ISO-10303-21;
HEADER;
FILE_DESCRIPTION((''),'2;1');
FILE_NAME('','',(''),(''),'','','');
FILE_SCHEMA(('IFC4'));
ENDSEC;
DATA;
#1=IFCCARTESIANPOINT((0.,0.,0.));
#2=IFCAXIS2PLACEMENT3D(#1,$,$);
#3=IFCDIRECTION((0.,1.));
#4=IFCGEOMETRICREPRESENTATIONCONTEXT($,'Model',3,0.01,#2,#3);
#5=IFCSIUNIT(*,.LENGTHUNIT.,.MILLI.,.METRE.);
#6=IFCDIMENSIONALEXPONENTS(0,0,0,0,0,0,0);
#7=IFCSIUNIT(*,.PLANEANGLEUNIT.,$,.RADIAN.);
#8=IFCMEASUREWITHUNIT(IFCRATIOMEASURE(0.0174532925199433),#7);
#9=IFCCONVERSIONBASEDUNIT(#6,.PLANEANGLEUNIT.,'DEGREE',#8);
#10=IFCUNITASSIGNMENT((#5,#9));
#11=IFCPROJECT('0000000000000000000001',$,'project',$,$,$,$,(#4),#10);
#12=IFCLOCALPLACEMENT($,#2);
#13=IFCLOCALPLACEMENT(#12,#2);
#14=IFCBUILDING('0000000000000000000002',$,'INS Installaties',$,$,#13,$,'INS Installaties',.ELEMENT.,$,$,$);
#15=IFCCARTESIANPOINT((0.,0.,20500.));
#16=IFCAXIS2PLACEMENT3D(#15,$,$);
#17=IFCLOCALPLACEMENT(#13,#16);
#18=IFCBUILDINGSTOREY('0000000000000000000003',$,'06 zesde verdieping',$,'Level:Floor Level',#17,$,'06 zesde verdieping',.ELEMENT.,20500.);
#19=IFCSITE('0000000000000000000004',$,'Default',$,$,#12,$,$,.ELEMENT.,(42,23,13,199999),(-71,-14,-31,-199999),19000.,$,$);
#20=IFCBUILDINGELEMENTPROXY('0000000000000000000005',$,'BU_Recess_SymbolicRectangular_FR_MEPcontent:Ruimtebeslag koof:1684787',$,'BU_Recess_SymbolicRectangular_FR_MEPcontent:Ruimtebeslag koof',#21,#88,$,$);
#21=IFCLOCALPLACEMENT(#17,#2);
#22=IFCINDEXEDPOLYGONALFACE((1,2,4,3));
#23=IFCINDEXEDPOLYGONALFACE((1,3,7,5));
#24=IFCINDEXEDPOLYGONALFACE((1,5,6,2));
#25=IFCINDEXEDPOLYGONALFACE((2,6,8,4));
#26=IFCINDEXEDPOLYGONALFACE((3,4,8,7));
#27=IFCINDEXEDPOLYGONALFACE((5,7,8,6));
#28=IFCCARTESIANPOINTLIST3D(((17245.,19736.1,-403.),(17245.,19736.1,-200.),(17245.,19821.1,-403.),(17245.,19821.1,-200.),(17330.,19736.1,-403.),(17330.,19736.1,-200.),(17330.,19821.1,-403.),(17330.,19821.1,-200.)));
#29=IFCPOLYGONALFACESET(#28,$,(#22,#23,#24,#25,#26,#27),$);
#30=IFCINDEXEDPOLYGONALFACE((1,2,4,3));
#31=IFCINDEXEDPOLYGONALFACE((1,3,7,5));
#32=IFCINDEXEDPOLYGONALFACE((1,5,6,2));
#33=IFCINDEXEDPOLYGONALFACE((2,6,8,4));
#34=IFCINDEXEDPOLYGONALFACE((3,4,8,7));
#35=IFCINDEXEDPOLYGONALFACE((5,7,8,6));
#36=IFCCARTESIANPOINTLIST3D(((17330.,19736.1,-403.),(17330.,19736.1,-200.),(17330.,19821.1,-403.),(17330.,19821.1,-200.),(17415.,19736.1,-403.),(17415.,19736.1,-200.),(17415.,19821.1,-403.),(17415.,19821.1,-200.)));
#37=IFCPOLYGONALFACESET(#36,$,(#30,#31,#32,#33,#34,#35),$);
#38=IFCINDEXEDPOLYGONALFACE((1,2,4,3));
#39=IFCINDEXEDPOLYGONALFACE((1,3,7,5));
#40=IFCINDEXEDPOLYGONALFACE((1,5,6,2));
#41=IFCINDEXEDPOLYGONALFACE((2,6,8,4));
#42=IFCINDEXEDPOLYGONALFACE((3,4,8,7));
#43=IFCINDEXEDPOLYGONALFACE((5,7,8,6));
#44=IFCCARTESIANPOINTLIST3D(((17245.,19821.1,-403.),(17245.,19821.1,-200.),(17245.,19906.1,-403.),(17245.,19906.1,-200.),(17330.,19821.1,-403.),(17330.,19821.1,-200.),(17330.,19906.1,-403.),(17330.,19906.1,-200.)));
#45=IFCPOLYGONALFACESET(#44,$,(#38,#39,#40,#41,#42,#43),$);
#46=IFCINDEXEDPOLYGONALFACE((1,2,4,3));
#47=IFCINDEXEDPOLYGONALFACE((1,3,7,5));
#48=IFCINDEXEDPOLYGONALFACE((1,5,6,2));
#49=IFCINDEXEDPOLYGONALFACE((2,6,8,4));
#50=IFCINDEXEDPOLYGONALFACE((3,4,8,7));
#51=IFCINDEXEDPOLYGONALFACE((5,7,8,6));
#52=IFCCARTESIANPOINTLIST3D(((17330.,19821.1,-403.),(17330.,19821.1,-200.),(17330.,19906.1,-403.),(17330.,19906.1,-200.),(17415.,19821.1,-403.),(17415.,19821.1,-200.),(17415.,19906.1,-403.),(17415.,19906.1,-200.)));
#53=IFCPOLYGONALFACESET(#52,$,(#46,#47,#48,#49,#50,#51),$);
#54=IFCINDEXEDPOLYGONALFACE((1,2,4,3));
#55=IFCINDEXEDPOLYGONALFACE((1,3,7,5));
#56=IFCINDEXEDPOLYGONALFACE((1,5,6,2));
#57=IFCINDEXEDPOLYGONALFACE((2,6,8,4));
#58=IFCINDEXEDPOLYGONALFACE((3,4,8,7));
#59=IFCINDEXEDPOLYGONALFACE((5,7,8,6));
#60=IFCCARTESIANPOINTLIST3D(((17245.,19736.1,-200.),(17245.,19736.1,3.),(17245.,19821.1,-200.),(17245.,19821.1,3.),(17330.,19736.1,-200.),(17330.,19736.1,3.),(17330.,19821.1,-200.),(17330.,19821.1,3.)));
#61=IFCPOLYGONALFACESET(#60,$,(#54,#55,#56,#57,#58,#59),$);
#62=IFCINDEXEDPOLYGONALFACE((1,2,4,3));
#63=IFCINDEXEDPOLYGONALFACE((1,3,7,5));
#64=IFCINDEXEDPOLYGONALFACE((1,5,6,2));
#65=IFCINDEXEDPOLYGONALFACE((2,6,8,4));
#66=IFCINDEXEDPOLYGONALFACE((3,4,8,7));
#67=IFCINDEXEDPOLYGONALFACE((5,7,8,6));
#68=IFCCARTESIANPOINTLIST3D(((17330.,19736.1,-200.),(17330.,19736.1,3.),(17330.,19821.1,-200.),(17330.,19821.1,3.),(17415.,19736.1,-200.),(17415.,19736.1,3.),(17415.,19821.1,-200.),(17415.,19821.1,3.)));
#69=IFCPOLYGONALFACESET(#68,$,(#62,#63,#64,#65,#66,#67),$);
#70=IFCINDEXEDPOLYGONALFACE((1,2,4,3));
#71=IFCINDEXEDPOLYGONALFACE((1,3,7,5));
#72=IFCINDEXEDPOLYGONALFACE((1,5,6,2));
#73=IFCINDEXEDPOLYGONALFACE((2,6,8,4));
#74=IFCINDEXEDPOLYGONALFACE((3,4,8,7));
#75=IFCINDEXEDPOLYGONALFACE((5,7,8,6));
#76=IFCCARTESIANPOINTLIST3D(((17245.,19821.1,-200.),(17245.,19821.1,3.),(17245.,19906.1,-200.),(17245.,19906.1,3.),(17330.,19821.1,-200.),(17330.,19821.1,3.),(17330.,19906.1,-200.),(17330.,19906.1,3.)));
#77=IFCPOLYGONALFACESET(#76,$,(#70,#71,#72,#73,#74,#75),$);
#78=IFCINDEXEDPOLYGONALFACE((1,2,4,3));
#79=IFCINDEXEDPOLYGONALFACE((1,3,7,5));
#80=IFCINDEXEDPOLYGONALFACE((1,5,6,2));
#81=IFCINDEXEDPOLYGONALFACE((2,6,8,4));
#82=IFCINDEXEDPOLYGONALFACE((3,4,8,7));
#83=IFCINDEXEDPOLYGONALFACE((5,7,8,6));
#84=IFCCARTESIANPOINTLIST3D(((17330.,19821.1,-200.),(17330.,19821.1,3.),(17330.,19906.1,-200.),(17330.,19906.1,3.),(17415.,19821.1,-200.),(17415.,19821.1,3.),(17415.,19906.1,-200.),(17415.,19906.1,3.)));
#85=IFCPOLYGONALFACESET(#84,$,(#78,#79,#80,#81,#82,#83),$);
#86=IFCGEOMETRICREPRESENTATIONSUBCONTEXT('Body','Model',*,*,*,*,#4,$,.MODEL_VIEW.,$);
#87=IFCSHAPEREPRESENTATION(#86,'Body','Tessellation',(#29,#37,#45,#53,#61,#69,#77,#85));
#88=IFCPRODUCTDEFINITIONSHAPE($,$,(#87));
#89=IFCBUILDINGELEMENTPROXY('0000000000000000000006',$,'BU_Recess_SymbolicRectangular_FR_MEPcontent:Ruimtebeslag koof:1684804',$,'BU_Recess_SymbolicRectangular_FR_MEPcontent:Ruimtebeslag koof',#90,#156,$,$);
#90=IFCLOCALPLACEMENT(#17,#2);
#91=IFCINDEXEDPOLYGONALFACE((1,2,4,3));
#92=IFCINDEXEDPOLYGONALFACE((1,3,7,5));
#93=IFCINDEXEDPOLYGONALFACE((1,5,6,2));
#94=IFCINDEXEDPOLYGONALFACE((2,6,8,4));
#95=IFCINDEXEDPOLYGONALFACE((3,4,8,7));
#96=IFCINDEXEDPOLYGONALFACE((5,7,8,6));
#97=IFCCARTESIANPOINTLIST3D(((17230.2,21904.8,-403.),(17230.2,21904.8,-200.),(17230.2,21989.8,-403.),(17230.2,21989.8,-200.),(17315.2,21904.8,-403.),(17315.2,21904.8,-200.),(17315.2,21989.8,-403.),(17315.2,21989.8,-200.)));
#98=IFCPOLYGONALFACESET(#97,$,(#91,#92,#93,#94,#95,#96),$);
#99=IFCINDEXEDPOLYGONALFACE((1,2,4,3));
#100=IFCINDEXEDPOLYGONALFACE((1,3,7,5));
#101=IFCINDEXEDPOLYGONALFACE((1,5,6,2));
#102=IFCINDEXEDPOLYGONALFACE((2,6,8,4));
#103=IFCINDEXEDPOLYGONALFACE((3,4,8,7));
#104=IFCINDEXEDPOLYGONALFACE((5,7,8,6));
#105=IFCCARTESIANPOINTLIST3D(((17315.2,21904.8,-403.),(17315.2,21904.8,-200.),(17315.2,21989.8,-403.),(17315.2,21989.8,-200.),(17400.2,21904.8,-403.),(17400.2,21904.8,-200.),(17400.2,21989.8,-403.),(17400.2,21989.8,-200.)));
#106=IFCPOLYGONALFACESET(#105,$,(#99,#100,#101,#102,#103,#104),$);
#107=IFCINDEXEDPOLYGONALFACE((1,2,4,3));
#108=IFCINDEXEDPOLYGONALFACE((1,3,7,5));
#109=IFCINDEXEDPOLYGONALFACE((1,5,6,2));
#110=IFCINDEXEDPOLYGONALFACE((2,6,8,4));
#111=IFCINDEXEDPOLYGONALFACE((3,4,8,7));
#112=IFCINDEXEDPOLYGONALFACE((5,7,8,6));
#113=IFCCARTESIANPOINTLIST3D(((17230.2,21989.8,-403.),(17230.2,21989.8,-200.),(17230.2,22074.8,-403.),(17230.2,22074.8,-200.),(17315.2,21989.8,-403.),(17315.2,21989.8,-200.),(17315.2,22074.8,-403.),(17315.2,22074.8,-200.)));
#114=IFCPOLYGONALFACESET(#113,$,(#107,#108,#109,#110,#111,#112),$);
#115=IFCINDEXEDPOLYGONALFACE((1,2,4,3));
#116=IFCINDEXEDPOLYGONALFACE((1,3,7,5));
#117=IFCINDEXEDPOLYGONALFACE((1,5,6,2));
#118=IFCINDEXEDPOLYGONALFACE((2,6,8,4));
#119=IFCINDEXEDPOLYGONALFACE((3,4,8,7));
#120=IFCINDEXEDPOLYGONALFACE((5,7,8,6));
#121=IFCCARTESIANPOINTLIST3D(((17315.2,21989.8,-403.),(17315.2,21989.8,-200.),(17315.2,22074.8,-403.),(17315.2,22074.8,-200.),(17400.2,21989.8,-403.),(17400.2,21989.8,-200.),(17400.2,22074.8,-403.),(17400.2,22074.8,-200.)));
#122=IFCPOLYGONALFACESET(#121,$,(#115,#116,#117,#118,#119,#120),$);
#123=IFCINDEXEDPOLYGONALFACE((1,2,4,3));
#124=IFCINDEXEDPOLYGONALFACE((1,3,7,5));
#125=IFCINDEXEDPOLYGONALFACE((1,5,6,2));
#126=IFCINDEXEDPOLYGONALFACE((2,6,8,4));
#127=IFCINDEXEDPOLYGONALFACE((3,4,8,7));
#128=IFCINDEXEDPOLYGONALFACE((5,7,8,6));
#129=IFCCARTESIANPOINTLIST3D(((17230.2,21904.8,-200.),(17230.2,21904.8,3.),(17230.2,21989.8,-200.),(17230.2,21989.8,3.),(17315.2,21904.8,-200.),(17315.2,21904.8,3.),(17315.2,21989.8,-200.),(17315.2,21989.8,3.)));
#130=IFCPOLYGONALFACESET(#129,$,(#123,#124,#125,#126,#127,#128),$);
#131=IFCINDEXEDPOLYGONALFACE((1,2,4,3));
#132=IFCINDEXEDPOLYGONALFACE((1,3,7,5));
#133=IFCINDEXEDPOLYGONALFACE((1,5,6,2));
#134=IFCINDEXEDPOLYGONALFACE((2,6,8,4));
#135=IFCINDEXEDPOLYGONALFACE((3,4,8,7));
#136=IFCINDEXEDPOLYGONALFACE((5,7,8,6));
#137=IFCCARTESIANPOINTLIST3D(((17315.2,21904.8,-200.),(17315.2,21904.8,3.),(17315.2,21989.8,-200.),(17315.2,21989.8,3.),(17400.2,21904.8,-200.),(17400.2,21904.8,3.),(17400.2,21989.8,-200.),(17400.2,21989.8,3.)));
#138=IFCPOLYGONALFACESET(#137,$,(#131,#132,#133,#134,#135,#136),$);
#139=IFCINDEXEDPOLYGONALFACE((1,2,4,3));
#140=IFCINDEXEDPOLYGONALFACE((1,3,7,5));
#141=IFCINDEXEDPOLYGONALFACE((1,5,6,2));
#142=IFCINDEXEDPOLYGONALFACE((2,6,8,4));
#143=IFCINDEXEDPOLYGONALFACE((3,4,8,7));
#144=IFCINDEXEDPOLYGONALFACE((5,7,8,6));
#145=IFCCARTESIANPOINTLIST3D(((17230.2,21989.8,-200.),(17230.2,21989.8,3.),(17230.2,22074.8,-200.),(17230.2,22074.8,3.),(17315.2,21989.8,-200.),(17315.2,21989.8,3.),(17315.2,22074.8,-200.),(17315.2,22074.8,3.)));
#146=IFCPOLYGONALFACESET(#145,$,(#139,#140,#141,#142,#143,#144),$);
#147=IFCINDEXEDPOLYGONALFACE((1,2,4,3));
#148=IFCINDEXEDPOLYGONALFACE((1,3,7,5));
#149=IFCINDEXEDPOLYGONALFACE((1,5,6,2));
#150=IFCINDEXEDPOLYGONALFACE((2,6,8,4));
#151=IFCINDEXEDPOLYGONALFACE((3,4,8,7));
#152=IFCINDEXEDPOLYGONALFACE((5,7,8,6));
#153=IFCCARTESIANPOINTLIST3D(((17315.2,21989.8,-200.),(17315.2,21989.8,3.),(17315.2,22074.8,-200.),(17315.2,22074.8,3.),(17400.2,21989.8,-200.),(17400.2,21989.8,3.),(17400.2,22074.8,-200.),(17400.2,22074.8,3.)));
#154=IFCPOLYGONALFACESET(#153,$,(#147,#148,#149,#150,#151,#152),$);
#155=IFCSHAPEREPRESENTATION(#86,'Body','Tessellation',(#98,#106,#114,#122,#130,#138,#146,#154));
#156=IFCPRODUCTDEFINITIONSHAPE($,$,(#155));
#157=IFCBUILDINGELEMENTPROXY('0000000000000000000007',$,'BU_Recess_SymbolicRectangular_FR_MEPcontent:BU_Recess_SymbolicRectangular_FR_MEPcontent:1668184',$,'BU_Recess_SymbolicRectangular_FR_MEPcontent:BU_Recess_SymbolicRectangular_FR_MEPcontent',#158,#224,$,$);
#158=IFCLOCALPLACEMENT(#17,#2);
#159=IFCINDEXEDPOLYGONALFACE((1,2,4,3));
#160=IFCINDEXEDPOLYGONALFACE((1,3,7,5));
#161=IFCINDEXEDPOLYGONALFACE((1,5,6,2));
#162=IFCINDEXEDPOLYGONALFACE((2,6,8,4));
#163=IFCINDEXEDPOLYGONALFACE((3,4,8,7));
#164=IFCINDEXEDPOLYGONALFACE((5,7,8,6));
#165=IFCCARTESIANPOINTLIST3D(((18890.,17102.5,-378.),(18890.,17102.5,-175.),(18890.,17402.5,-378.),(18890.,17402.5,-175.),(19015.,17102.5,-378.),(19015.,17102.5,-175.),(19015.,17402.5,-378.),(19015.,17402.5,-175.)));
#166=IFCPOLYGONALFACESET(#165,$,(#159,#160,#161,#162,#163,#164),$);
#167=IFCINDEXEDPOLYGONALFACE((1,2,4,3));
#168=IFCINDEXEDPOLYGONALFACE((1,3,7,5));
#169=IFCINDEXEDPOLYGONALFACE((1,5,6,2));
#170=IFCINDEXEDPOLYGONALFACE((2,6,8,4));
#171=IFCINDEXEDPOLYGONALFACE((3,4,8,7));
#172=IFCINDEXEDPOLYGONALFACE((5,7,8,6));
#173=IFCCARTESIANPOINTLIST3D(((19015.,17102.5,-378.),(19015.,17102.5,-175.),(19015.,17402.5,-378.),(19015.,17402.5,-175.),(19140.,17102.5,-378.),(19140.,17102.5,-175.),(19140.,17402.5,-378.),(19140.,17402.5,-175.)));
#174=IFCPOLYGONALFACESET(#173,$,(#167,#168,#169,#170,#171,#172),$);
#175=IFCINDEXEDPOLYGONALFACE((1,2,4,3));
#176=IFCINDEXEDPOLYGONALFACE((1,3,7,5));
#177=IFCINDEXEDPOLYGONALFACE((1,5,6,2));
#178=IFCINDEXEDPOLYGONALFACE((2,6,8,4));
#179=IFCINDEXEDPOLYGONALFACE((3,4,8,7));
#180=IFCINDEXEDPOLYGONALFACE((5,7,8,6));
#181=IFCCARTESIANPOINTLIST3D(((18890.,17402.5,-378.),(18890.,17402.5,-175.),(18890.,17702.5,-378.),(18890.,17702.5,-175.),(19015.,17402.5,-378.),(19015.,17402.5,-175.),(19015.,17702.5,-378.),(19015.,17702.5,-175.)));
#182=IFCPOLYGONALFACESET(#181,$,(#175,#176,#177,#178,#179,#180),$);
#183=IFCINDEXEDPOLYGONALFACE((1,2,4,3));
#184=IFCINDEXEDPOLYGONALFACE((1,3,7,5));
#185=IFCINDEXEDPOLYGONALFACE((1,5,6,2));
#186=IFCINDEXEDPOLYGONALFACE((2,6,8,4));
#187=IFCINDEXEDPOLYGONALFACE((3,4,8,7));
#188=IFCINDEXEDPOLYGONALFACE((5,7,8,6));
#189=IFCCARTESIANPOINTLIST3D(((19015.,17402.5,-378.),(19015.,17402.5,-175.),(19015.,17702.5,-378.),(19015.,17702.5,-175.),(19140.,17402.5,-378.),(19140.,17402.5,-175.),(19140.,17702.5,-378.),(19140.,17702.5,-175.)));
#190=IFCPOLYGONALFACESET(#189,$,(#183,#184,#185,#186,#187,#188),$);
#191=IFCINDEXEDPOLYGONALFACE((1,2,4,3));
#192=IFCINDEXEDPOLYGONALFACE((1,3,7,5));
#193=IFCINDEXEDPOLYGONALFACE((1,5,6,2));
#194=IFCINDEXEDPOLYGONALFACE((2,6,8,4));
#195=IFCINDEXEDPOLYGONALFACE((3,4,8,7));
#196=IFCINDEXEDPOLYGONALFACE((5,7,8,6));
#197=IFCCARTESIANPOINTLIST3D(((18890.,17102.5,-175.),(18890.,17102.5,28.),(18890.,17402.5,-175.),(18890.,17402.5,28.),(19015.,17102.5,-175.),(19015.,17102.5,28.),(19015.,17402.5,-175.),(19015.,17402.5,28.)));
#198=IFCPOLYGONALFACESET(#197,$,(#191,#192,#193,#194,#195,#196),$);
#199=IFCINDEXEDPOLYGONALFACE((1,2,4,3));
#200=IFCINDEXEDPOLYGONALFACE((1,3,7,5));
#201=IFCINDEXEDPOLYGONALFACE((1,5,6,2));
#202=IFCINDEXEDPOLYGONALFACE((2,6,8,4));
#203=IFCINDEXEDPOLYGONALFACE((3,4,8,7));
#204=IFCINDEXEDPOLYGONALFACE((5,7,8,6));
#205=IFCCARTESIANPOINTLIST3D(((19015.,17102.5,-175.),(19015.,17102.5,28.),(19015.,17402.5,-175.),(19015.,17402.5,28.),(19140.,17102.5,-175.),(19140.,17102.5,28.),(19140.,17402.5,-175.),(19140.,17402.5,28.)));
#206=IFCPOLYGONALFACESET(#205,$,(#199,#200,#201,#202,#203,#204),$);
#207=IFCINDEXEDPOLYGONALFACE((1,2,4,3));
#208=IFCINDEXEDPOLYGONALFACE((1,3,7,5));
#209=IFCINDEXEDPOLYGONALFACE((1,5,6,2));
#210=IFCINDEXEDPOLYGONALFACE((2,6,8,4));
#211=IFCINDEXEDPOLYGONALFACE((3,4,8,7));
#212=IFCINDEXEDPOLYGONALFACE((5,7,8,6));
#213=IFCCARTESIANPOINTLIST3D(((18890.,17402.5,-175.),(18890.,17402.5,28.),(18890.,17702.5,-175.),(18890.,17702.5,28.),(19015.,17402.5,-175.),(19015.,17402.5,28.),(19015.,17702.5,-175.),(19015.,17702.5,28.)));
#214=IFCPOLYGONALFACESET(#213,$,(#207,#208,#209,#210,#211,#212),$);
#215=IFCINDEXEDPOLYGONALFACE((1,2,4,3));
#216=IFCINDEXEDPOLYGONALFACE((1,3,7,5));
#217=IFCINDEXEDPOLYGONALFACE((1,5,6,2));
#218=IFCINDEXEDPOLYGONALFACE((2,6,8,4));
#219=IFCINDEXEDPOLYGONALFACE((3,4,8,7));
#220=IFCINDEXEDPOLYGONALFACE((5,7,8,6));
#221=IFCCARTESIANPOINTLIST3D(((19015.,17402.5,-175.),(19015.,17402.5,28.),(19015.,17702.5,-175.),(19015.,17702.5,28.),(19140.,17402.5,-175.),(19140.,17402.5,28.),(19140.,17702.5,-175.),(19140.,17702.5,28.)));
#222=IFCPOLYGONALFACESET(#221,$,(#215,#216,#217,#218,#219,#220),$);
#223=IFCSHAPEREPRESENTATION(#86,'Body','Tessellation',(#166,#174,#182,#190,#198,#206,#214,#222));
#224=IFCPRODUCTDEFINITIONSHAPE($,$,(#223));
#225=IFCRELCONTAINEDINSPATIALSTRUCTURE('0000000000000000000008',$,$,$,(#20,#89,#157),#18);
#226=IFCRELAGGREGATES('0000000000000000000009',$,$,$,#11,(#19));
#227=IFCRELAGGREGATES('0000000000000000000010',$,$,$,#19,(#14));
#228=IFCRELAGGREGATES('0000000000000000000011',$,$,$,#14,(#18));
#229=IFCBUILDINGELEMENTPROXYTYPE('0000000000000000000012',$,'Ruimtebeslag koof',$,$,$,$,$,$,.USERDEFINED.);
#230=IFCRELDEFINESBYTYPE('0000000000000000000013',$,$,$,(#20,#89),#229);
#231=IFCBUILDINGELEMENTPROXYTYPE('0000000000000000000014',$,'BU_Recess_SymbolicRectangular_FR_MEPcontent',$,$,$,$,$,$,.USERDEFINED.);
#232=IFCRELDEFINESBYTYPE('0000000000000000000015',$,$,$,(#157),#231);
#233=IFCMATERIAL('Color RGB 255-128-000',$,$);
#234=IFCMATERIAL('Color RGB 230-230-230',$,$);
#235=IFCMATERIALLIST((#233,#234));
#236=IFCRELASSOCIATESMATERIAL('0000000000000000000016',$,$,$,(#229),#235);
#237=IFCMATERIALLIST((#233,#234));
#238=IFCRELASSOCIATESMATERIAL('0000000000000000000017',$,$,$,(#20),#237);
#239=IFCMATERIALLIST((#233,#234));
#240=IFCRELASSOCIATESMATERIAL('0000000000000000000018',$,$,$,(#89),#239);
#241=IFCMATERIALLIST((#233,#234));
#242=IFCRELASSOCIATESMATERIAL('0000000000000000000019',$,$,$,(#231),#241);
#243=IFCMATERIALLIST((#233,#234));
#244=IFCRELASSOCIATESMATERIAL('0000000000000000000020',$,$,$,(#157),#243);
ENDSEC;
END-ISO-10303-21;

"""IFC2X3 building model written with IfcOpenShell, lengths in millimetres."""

from ifc_helpers import new_model, entity, si_unit, converted_unit, direction, frame, frame_2d, origin, origin_2d_with_axis, place, context, subcontext, project, spatial, rectangle, extrude, source, transform, mapped, material, material_list, type_object, type_shapes, element, save


model = new_model("IFC2X3")

# Units and contexts
model_context = context("Model", 3, precision=0.01, world=origin(), true_north=direction((0.0, 1.0)))
body_context = subcontext(model_context, "Body", "Model", "MODEL_VIEW")
ifc_project = project(units=[si_unit("LENGTHUNIT", "METRE", prefix="MILLI"), converted_unit("PLANEANGLEUNIT", "DEGREE", entity("IfcRatioMeasure", 0.0174532925199433), si_unit("PLANEANGLEUNIT", "RADIAN"), dimensions=[0, 0, 0, 0, 0, 0, 0])], contexts=[model_context])

# Site, building, storey
site_placement = place(None, origin())
site = spatial("IfcSite", under=ifc_project, at=site_placement, Name="Default", CompositionType="ELEMENT", RefLatitude=(42, 23, 13, 199999), RefLongitude=(-71, -14, -31, -199999), RefElevation=19000.0)
building_placement = place(site_placement, origin())
building = spatial("IfcBuilding", under=site, at=building_placement, Name="INS Installaties", LongName="INS Installaties", CompositionType="ELEMENT")
storey_placement = place(building_placement, frame((0.0, 0.0, 20500.0)))
storey = spatial("IfcBuildingStorey", under=building, at=storey_placement, Name="06 zesde verdieping", ObjectType="Level:Floor Level", LongName="06 zesde verdieping", CompositionType="ELEMENT", Elevation=20500.0)

# Building element proxies
ifc_material_1 = material(Name="Color RGB 255-128-000")
ifc_material_2 = material(Name="Color RGB 230-230-230")
ifc_material_list_1 = material_list([ifc_material_1, ifc_material_2])
building_element_proxy_type_1 = type_object("IfcBuildingElementProxyType", Name="Ruimtebeslag koof", PredefinedType="USERDEFINED", material=ifc_material_list_1)
shared_shape_1 = source(origin(), body_context, "Body", "SweptSolid", [
    extrude(rectangle(XDim=85.0, YDim=85.0, at=origin_2d_with_axis()), frame((42.5, 42.5, -403.0), z_axis=(0.0, 0.0, 1.0), x_axis=(0.0, -1.0, 0.0)), (0.0, 0.0, 1.0), 203.0),
    extrude(rectangle(XDim=85.0, YDim=85.0, at=origin_2d_with_axis()), frame((-42.5, 42.5, -403.0), z_axis=(0.0, 0.0, 1.0), x_axis=(-1.0, 0.0, 0.0)), (0.0, 0.0, 1.0), 203.0),
    extrude(rectangle(XDim=85.0, YDim=85.0, at=frame_2d((0.0, 0.0), x_axis=(1.0, 0.0))), frame((42.5, -42.5, -403.0)), (0.0, 0.0, 1.0), 203.0),
    extrude(rectangle(XDim=85.0, YDim=85.0, at=origin_2d_with_axis()), frame((-42.5, -42.5, -403.0), z_axis=(0.0, 0.0, 1.0), x_axis=(0.0, 1.0, 0.0)), (0.0, 0.0, 1.0), 203.0),
    extrude(rectangle(XDim=85.0, YDim=85.0, at=origin_2d_with_axis()), frame((42.5, 42.5, -200.0), z_axis=(0.0, 0.0, 1.0), x_axis=(0.0, -1.0, 0.0)), (0.0, 0.0, 1.0), 203.0),
    extrude(rectangle(XDim=85.0, YDim=85.0, at=frame_2d((0.0, 0.0), x_axis=(1.0, 0.0))), frame((-42.5, 42.5, -200.0), z_axis=(0.0, 0.0, 1.0), x_axis=(-1.0, 0.0, 0.0)), (0.0, 0.0, 1.0), 203.0),
    extrude(rectangle(XDim=85.0, YDim=85.0, at=frame_2d((0.0, 0.0), x_axis=(1.0, 0.0))), frame((42.5, -42.5, -200.0)), (0.0, 0.0, 1.0), 203.0),
    extrude(rectangle(XDim=85.0, YDim=85.0, at=origin_2d_with_axis()), frame((-42.5, -42.5, -200.0), z_axis=(0.0, 0.0, 1.0), x_axis=(0.0, 1.0, 0.0)), (0.0, 0.0, 1.0), 203.0),
])
type_shapes(building_element_proxy_type_1, [shared_shape_1])
ifc_material_list_2 = material_list([ifc_material_1, ifc_material_2])
proxy_1_placement = place(storey_placement, frame((17330.0, 19821.1, 0.0), z_axis=(0.0, 0.0, 1.0), x_axis=(-1.0, 0.0, 0.0)))
element("IfcBuildingElementProxy", 1, at=proxy_1_placement, inside=storey, type_object=building_element_proxy_type_1, material=ifc_material_list_2, Name="BU_Recess_SymbolicRectangular_FR_MEPcontent:Ruimtebeslag koof:1684787", ObjectType="BU_Recess_SymbolicRectangular_FR_MEPcontent:Ruimtebeslag koof", context=body_context, shape_type="MappedRepresentation", body=[
    mapped(shared_shape_1, transform((0.0, 0.0, 0.0), scale=1.0)),
])
ifc_material_list_3 = material_list([ifc_material_1, ifc_material_2])
proxy_2_placement = place(storey_placement, frame((17315.2, 21989.8, 0.0), z_axis=(0.0, 0.0, 1.0), x_axis=(-1.0, 0.0, 0.0)))
element("IfcBuildingElementProxy", 2, at=proxy_2_placement, inside=storey, type_object=building_element_proxy_type_1, material=ifc_material_list_3, Name="BU_Recess_SymbolicRectangular_FR_MEPcontent:Ruimtebeslag koof:1684804", ObjectType="BU_Recess_SymbolicRectangular_FR_MEPcontent:Ruimtebeslag koof", context=body_context, shape_type="MappedRepresentation", body=[
    mapped(shared_shape_1, transform((0.0, 0.0, 0.0), scale=1.0)),
])
ifc_material_list_4 = material_list([ifc_material_1, ifc_material_2])
ifc_material_list_5 = material_list([ifc_material_1, ifc_material_2])
building_element_proxy_type_2 = type_object("IfcBuildingElementProxyType", Name="BU_Recess_SymbolicRectangular_FR_MEPcontent", PredefinedType="USERDEFINED", material=ifc_material_list_5)
shared_shape_2 = source(origin(), body_context, "Body", "SweptSolid", [
    extrude(rectangle(XDim=300.0, YDim=125.0, at=origin_2d_with_axis()), frame((62.5, 150.0, -403.0), z_axis=(0.0, 0.0, 1.0), x_axis=(0.0, -1.0, 0.0)), (0.0, 0.0, 1.0), 203.0),
    extrude(rectangle(XDim=125.0, YDim=300.0, at=origin_2d_with_axis()), frame((-62.5, 150.0, -403.0), z_axis=(0.0, 0.0, 1.0), x_axis=(-1.0, 0.0, 0.0)), (0.0, 0.0, 1.0), 203.0),
    extrude(rectangle(XDim=125.0, YDim=300.0, at=origin_2d_with_axis()), frame((62.5, -150.0, -403.0)), (0.0, 0.0, 1.0), 203.0),
    extrude(rectangle(XDim=300.0, YDim=125.0, at=origin_2d_with_axis()), frame((-62.5, -150.0, -403.0), z_axis=(0.0, 0.0, 1.0), x_axis=(0.0, 1.0, 0.0)), (0.0, 0.0, 1.0), 203.0),
    extrude(rectangle(XDim=300.0, YDim=125.0, at=origin_2d_with_axis()), frame((62.5, 150.0, -200.0), z_axis=(0.0, 0.0, 1.0), x_axis=(0.0, -1.0, 0.0)), (0.0, 0.0, 1.0), 203.0),
    extrude(rectangle(XDim=125.0, YDim=300.0, at=frame_2d((0.0, 0.0), x_axis=(1.0, 0.0))), frame((-62.5, 150.0, -200.0), z_axis=(0.0, 0.0, 1.0), x_axis=(-1.0, 0.0, 0.0)), (0.0, 0.0, 1.0), 203.0),
    extrude(rectangle(XDim=125.0, YDim=300.0, at=frame_2d((0.0, 0.0), x_axis=(1.0, 0.0))), frame((62.5, -150.0, -200.0)), (0.0, 0.0, 1.0), 203.0),
    extrude(rectangle(XDim=300.0, YDim=125.0, at=origin_2d_with_axis()), frame((-62.5, -150.0, -200.0), z_axis=(0.0, 0.0, 1.0), x_axis=(0.0, 1.0, 0.0)), (0.0, 0.0, 1.0), 203.0),
])
type_shapes(building_element_proxy_type_2, [shared_shape_2])
proxy_3_placement = place(storey_placement, frame((19015.0, 17402.5, 25.0), z_axis=(0.0, 0.0, 1.0), x_axis=(-1.0, 0.0, 0.0)))
element("IfcBuildingElementProxy", 3, at=proxy_3_placement, inside=storey, type_object=building_element_proxy_type_2, material=ifc_material_list_4, Name="BU_Recess_SymbolicRectangular_FR_MEPcontent:BU_Recess_SymbolicRectangular_FR_MEPcontent:1668184", ObjectType="BU_Recess_SymbolicRectangular_FR_MEPcontent:BU_Recess_SymbolicRectangular_FR_MEPcontent", context=body_context, shape_type="MappedRepresentation", body=[
    mapped(shared_shape_2, transform((0.0, 0.0, 0.0), scale=1.0)),
])

save(model, "model.ifc")
